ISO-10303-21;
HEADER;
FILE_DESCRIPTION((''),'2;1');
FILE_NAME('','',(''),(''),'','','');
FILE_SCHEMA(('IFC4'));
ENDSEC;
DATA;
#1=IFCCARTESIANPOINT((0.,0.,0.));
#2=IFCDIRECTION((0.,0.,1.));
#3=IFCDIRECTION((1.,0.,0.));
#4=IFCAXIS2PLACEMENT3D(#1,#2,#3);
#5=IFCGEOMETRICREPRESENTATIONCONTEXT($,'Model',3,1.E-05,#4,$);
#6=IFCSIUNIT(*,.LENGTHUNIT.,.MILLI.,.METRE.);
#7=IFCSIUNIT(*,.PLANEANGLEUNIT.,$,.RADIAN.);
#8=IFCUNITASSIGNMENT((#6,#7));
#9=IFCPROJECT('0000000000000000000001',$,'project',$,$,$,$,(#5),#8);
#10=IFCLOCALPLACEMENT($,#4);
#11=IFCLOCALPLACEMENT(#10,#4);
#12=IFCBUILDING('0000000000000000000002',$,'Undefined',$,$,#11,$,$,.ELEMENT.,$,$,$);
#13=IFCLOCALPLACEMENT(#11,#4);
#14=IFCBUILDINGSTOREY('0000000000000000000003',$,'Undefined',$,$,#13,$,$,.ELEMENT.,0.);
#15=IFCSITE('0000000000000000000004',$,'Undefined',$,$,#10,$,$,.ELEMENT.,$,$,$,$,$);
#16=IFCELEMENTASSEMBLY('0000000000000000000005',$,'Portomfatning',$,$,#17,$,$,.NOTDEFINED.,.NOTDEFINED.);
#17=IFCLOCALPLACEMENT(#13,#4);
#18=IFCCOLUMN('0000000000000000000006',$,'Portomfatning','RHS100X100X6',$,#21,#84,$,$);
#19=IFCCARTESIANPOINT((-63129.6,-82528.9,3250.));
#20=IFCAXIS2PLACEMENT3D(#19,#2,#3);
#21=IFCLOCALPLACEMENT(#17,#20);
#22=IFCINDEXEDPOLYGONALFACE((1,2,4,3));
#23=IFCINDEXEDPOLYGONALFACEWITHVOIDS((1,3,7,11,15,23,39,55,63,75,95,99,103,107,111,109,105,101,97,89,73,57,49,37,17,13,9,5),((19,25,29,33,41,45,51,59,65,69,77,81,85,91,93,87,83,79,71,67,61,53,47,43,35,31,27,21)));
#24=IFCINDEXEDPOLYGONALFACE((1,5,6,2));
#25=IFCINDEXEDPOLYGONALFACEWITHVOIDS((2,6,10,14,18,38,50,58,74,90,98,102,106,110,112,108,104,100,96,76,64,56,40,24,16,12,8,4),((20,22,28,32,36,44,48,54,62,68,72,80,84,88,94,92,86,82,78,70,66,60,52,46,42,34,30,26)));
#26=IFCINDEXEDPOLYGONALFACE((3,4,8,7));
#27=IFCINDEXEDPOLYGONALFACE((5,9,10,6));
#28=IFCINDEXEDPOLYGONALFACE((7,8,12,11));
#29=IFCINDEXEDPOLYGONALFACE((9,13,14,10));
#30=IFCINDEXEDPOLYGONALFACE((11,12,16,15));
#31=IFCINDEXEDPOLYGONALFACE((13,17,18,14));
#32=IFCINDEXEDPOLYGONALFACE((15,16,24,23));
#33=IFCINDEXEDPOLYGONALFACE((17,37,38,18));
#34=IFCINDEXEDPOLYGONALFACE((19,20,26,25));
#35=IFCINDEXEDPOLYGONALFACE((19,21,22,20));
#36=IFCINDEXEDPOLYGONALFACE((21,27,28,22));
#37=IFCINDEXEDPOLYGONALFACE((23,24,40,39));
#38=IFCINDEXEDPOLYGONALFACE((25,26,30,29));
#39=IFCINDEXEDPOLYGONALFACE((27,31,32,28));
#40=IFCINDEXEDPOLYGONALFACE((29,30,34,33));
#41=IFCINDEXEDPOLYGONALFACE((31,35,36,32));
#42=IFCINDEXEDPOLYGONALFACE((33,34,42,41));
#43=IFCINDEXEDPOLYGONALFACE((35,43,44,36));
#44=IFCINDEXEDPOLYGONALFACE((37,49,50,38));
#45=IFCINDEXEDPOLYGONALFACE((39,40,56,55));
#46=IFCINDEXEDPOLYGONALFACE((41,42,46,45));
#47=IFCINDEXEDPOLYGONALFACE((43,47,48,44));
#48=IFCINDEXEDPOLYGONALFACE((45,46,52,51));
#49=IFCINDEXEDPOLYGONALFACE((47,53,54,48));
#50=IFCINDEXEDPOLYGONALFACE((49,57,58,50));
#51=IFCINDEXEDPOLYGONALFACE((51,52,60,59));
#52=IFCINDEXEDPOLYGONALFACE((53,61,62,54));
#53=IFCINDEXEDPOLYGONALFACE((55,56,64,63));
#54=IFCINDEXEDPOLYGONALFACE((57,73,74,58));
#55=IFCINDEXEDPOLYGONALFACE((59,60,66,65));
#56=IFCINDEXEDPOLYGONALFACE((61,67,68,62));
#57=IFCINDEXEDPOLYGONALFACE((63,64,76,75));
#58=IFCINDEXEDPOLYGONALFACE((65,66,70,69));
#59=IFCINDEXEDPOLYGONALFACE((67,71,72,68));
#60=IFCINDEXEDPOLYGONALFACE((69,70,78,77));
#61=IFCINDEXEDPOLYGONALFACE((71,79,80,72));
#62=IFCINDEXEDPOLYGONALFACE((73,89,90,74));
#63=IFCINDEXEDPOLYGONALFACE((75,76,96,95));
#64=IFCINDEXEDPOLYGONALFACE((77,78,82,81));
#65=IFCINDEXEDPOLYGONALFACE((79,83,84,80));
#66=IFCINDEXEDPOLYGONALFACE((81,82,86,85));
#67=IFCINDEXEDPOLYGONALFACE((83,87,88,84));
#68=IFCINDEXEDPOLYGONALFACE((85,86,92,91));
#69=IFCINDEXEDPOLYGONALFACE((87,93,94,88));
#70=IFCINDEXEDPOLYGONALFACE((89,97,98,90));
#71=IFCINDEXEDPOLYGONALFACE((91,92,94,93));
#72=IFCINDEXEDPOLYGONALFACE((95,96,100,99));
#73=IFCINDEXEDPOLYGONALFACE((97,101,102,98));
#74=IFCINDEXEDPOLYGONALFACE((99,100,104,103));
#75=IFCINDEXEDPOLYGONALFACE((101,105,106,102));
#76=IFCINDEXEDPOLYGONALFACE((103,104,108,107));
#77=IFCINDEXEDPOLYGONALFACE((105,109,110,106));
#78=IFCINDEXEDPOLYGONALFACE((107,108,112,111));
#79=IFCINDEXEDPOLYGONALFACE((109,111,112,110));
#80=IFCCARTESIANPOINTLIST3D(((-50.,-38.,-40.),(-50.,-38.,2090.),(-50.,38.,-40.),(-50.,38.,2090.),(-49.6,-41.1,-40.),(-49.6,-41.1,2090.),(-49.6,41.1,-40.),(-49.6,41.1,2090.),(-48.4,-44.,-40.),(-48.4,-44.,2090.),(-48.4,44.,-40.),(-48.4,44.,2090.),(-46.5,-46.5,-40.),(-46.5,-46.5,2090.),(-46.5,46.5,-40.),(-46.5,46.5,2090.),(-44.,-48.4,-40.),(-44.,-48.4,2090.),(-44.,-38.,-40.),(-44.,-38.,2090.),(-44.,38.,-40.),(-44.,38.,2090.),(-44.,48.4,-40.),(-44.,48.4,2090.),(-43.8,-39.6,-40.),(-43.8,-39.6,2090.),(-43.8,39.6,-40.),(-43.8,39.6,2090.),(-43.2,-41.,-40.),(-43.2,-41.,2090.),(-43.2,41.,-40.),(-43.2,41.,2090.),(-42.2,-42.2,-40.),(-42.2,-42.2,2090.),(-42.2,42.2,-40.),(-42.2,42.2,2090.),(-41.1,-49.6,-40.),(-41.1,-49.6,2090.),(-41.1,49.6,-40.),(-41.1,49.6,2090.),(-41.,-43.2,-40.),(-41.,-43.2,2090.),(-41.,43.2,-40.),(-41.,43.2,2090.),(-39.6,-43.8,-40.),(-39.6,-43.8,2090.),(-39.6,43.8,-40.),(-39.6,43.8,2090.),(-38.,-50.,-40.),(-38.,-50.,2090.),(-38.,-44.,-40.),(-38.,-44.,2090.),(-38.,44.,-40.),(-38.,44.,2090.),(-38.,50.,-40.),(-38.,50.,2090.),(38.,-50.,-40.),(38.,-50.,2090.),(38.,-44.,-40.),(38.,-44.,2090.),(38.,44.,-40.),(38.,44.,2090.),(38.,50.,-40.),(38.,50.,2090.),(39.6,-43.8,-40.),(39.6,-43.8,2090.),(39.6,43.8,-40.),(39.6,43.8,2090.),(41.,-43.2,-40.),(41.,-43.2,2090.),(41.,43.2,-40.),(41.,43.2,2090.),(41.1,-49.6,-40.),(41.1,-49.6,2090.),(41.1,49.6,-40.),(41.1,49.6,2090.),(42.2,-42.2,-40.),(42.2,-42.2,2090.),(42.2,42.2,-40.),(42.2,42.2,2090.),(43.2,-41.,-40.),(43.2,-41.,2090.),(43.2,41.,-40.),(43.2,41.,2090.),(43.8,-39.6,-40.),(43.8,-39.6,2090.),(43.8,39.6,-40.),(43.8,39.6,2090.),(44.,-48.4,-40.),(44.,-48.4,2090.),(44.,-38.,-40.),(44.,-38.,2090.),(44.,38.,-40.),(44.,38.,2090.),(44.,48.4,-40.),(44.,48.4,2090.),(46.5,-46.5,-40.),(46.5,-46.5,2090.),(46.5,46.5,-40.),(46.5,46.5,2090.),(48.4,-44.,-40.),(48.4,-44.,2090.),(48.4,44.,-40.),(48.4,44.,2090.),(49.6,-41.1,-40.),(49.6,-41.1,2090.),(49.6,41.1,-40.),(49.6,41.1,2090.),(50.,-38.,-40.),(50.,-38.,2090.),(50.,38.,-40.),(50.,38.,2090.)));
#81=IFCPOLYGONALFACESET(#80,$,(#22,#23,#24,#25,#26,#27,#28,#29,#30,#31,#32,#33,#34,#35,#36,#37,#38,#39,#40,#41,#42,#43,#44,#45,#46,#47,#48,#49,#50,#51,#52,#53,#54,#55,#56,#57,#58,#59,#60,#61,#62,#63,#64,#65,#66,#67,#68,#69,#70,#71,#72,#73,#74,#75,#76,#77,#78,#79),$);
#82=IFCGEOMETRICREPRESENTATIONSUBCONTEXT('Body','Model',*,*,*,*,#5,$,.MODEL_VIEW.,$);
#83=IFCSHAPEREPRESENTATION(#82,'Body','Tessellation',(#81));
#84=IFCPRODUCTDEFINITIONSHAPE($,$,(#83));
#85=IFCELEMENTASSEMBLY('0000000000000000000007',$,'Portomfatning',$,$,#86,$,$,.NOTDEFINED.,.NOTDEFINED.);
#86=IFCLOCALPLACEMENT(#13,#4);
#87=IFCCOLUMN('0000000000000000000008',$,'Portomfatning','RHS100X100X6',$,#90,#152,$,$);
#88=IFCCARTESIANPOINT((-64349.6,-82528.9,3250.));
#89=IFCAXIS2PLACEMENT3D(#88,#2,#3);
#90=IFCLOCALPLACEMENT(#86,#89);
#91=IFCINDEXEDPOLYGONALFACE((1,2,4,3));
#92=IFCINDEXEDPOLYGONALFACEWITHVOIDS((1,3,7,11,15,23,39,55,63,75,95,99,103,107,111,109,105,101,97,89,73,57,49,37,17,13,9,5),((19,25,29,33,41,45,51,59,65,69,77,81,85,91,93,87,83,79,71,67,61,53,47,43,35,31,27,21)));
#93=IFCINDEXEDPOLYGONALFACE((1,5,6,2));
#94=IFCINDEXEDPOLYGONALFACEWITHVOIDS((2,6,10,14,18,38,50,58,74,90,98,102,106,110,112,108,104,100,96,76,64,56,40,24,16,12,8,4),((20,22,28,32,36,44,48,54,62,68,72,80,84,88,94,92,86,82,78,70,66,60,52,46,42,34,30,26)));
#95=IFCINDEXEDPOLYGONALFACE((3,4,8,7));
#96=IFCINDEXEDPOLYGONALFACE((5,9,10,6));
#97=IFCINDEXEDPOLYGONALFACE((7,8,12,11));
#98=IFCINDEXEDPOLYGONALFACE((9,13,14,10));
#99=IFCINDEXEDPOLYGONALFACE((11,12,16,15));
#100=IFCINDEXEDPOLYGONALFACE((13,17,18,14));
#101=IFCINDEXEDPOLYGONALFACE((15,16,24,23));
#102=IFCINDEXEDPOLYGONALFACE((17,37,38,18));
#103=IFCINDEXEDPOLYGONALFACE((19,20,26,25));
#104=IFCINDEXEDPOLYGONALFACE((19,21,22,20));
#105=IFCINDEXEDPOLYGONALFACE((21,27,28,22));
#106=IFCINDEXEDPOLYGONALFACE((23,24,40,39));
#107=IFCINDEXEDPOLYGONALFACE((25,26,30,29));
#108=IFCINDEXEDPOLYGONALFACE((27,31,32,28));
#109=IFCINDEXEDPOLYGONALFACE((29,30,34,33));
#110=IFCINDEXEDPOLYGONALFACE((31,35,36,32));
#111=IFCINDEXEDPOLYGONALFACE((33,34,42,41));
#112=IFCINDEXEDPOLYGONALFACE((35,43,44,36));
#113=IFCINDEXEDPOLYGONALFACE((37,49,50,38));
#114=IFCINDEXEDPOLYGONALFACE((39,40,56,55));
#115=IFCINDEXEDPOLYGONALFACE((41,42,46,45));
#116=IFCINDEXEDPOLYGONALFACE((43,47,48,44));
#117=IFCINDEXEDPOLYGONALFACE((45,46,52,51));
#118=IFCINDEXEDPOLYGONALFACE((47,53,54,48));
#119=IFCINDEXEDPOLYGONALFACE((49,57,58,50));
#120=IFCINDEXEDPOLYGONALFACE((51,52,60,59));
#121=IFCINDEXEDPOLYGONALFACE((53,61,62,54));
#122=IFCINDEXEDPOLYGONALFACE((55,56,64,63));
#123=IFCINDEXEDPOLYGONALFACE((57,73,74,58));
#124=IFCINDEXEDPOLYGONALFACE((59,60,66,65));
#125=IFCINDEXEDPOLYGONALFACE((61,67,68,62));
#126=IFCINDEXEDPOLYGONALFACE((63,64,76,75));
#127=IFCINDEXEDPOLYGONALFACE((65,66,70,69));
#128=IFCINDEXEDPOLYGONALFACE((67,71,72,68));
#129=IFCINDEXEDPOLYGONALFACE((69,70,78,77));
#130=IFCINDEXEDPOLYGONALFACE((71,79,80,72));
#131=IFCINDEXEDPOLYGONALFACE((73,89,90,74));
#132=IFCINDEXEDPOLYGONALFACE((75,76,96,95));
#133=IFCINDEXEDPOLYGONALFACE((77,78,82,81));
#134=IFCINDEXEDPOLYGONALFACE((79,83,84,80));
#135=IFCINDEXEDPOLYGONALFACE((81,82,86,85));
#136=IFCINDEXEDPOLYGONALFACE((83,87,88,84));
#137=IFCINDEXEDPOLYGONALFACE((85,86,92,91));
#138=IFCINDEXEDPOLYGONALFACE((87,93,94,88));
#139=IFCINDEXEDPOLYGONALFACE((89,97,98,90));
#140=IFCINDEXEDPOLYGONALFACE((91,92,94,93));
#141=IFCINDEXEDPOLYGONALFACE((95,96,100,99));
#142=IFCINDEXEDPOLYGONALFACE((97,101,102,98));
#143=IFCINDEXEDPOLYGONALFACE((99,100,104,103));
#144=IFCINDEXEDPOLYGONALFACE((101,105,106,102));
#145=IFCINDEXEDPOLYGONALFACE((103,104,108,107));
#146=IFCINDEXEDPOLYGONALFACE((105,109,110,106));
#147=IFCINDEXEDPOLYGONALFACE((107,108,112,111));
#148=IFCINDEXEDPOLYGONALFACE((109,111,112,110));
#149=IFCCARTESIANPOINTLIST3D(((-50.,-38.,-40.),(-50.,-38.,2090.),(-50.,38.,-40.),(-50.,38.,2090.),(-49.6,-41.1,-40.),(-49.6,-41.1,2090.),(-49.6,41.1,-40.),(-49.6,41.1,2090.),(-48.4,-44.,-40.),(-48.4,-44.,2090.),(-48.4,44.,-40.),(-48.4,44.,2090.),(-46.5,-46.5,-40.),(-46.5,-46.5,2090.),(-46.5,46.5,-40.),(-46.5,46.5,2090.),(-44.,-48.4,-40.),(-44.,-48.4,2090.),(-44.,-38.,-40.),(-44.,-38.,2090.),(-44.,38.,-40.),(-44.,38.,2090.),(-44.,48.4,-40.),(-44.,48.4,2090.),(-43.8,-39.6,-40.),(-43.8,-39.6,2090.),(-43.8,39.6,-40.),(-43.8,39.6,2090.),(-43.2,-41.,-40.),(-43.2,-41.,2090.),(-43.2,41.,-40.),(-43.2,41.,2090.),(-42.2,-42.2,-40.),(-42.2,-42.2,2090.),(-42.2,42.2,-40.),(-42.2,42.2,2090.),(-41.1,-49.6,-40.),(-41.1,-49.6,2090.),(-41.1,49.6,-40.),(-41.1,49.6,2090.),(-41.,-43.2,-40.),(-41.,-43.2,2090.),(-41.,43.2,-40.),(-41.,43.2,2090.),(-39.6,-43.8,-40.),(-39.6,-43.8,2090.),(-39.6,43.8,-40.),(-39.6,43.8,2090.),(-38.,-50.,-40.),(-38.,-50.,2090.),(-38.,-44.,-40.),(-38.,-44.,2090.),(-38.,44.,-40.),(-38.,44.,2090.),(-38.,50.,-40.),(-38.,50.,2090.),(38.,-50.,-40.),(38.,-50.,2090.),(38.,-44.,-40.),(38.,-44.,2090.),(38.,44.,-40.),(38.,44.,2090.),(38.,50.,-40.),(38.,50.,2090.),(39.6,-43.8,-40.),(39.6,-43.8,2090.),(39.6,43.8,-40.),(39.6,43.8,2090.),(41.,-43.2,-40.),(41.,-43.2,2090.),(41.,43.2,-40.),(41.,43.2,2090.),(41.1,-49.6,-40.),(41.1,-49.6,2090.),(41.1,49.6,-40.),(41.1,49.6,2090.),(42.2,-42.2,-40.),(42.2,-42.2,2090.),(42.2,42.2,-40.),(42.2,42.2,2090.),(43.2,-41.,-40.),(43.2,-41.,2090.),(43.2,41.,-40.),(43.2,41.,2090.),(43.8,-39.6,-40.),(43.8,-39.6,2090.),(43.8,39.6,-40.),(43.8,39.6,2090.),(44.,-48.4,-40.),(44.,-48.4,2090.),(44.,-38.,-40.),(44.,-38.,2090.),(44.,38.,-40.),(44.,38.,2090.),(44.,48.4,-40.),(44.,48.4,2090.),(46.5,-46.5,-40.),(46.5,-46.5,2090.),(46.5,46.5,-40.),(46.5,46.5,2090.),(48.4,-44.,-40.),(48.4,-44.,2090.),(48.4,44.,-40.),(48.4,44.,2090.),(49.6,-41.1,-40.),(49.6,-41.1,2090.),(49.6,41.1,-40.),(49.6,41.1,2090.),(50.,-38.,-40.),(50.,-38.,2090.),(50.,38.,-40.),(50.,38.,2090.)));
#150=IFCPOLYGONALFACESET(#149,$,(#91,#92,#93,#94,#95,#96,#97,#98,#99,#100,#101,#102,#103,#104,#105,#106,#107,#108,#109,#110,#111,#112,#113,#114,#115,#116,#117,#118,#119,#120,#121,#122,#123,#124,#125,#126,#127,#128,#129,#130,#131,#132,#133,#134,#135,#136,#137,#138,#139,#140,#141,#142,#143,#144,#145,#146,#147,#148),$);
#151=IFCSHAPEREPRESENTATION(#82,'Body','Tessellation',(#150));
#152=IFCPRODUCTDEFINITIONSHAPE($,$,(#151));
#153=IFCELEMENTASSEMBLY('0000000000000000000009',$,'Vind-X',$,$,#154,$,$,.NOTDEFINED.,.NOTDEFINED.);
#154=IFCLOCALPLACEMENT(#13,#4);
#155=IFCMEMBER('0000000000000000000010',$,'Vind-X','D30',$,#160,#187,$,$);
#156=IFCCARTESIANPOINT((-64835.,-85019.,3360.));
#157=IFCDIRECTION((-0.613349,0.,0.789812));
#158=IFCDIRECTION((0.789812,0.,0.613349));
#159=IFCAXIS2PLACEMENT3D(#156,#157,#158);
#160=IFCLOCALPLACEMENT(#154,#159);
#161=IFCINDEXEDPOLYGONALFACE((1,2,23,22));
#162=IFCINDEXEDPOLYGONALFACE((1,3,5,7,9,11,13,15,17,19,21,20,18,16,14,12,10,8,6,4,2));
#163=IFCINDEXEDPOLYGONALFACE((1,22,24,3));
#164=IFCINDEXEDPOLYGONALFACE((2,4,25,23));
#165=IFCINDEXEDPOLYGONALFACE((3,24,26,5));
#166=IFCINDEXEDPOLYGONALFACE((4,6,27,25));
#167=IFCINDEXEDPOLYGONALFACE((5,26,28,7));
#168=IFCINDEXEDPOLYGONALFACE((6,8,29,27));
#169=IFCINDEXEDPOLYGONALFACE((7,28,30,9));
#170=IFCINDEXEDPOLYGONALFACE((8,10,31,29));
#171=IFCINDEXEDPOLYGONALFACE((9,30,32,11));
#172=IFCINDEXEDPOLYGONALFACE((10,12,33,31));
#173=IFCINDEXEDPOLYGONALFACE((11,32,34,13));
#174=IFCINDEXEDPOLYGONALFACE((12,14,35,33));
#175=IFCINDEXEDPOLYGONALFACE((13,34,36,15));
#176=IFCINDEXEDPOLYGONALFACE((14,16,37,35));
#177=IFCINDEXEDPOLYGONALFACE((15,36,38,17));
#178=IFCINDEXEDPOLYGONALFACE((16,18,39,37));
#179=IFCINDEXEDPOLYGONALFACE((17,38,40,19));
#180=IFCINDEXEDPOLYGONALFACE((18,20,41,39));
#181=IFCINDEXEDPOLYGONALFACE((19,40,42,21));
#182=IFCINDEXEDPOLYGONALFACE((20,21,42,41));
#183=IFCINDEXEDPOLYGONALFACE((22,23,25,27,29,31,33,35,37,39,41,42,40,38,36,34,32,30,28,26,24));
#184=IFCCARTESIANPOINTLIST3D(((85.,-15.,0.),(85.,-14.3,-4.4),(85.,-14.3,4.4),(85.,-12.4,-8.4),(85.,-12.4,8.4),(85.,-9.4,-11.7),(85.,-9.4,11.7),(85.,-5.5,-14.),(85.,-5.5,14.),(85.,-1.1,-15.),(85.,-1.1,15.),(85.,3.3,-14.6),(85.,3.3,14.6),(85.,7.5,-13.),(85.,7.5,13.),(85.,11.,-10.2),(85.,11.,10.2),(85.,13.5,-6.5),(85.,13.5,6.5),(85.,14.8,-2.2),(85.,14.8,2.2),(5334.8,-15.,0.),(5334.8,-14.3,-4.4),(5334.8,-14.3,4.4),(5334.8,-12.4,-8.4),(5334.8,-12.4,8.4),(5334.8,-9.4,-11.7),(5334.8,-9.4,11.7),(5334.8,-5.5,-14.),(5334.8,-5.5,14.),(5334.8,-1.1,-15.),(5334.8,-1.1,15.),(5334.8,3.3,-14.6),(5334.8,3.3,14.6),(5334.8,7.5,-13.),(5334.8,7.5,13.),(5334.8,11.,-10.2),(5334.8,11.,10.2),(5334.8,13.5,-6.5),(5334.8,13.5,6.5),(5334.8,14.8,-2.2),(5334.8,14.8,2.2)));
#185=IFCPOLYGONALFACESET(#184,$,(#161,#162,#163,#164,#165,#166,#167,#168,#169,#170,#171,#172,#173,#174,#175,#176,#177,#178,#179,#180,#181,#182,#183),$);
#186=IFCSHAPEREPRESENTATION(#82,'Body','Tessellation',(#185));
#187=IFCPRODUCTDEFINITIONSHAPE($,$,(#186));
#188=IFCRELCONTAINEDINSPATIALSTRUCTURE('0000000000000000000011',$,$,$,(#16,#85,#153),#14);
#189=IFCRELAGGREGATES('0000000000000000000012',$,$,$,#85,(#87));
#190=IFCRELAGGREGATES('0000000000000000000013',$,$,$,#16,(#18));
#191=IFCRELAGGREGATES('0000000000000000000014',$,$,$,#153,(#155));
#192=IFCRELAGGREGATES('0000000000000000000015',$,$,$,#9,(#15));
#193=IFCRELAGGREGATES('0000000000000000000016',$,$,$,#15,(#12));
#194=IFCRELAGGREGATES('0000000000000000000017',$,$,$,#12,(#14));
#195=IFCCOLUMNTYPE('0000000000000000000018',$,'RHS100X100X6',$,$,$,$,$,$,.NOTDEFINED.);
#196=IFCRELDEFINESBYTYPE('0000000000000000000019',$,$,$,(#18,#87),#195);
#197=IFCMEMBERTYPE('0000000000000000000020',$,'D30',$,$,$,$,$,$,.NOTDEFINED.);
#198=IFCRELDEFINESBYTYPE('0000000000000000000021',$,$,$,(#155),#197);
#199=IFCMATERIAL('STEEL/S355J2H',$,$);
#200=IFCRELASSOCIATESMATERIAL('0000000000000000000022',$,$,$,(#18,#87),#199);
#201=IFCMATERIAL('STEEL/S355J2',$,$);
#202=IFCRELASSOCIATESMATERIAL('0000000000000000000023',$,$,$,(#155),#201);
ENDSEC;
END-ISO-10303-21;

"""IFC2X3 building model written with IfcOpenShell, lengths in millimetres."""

from ifc_helpers import new_model, si_unit, frame, origin_with_axes, origin_2d_with_axis, place, context, subcontext, project, spatial, hollow_rectangle, circle, extrude, clip, halfspace, material, type_object, element, aggregate, save


model = new_model("IFC2X3")

# Units and contexts
model_context = context("Model", 3, precision=1e-05, world=origin_with_axes())
body_context = subcontext(model_context, "Body", "Model", "MODEL_VIEW")
ifc_project = project(units=[si_unit("LENGTHUNIT", "METRE", prefix="MILLI"), si_unit("PLANEANGLEUNIT", "RADIAN")], contexts=[model_context])

# Site, building, storey
site_placement = place(None, origin_with_axes())
site = spatial("IfcSite", under=ifc_project, at=site_placement, Name="Undefined", CompositionType="ELEMENT")
building_placement = place(site_placement, origin_with_axes())
building = spatial("IfcBuilding", under=site, at=building_placement, Name="Undefined", CompositionType="ELEMENT")
storey_placement = place(building_placement, origin_with_axes())
storey = spatial("IfcBuildingStorey", under=building, at=storey_placement, Name="Undefined", CompositionType="ELEMENT", Elevation=0.0)

# Element assemblies, columns
assembly_1_placement = place(storey_placement, origin_with_axes())
assembly_1 = element("IfcElementAssembly", 1, at=assembly_1_placement, inside=storey, Name="Portomfatning", AssemblyPlace="NOTDEFINED", PredefinedType="NOTDEFINED")
ifc_material_1 = material(Name="STEEL/S355J2H")
column_type = type_object("IfcColumnType", Name="RHS100X100X6", PredefinedType="NOTDEFINED")
column_1_placement = place(assembly_1_placement, frame((-63129.6, -82528.9, 3250.0), z_axis=(0.0, 0.0, 1.0), x_axis=(1.0, 0.0, 0.0)))
column_1 = element("IfcColumn", 2, at=column_1_placement, type_object=column_type, material=ifc_material_1, Name="Portomfatning", Description="RHS100X100X6", context=body_context, shape_type="Clipping", body=[
    clip(clip(extrude(hollow_rectangle(XDim=100.0, YDim=100.0, WallThickness=6.0, InnerFilletRadius=6.0, OuterFilletRadius=12.0, at=origin_2d_with_axis()), frame((0.0, 0.0, 2100.0), z_axis=(0.0, 0.0, -1.0), x_axis=(0.0, 1.0, 0.0)), (0.0, 0.0, 1.0), 2140.0), halfspace(frame((-50.0, 0.0, 2090.0), z_axis=(0.0, 0.0, -1.0), x_axis=(0.0, -1.0, 0.0)), True)), halfspace(frame((0.0, 50.0, -40.0), z_axis=(0.0, 0.0, 1.0), x_axis=(1.0, 0.0, 0.0)), True)),
])
assembly_2_placement = place(storey_placement, origin_with_axes())
assembly_2 = element("IfcElementAssembly", 3, at=assembly_2_placement, inside=storey, Name="Portomfatning", AssemblyPlace="NOTDEFINED", PredefinedType="NOTDEFINED")
column_2_placement = place(assembly_2_placement, frame((-64349.6, -82528.9, 3250.0), z_axis=(0.0, 0.0, 1.0), x_axis=(1.0, 0.0, 0.0)))
column_2 = element("IfcColumn", 4, at=column_2_placement, type_object=column_type, material=ifc_material_1, Name="Portomfatning", Description="RHS100X100X6", context=body_context, shape_type="Clipping", body=[
    clip(clip(extrude(hollow_rectangle(XDim=100.0, YDim=100.0, WallThickness=6.0, InnerFilletRadius=6.0, OuterFilletRadius=12.0, at=origin_2d_with_axis()), frame((0.0, 0.0, 2100.0), z_axis=(0.0, 0.0, -1.0), x_axis=(0.0, 1.0, 0.0)), (0.0, 0.0, 1.0), 2140.0), halfspace(frame((50.0, 0.0, 2090.0), z_axis=(0.0, 0.0, -1.0), x_axis=(0.0, 1.0, 0.0)), True)), halfspace(frame((0.0, 50.0, -40.0), z_axis=(0.0, 0.0, 1.0), x_axis=(1.0, 0.0, 0.0)), True)),
])

# Element assembly, member
assembly_3_placement = place(storey_placement, origin_with_axes())
assembly_3 = element("IfcElementAssembly", 5, at=assembly_3_placement, inside=storey, Name="Vind-X", AssemblyPlace="NOTDEFINED", PredefinedType="NOTDEFINED")
ifc_material_2 = material(Name="STEEL/S355J2")
member_type_1 = type_object("IfcMemberType", Name="D30", PredefinedType="NOTDEFINED")
member_1_placement = place(assembly_3_placement, frame((-64835.0, -85019.0, 3360.0), z_axis=(-0.613349, 0.0, 0.789812), x_axis=(0.789812, 0.0, 0.613349)))
member_1 = element("IfcMember", 6, at=member_1_placement, type_object=member_type_1, material=ifc_material_2, Name="Vind-X", Description="D30", context=body_context, shape_type="Clipping", body=[
    clip(clip(extrude(circle(Radius=15.0, at=origin_2d_with_axis()), frame((5999.8, 0.0, 0.0), z_axis=(-1.0, 0.0, 0.0), x_axis=(0.0, -1.0, 0.0)), (0.0, 0.0, 1.0), 5999.9), halfspace(frame((5334.8, -6.0, 10.2), z_axis=(1.0, 0.0, 0.0), x_axis=(0.0, 1.0, 0.0)), False)), halfspace(frame((85.0, -6.0, 16.0), z_axis=(1.0, 0.0, 0.0), x_axis=(0.0, 1.0, 0.0)), True)),
])

aggregate(assembly_2, [column_2])
aggregate(assembly_1, [column_1])
aggregate(assembly_3, [member_1])

save(model, "model.ifc")
